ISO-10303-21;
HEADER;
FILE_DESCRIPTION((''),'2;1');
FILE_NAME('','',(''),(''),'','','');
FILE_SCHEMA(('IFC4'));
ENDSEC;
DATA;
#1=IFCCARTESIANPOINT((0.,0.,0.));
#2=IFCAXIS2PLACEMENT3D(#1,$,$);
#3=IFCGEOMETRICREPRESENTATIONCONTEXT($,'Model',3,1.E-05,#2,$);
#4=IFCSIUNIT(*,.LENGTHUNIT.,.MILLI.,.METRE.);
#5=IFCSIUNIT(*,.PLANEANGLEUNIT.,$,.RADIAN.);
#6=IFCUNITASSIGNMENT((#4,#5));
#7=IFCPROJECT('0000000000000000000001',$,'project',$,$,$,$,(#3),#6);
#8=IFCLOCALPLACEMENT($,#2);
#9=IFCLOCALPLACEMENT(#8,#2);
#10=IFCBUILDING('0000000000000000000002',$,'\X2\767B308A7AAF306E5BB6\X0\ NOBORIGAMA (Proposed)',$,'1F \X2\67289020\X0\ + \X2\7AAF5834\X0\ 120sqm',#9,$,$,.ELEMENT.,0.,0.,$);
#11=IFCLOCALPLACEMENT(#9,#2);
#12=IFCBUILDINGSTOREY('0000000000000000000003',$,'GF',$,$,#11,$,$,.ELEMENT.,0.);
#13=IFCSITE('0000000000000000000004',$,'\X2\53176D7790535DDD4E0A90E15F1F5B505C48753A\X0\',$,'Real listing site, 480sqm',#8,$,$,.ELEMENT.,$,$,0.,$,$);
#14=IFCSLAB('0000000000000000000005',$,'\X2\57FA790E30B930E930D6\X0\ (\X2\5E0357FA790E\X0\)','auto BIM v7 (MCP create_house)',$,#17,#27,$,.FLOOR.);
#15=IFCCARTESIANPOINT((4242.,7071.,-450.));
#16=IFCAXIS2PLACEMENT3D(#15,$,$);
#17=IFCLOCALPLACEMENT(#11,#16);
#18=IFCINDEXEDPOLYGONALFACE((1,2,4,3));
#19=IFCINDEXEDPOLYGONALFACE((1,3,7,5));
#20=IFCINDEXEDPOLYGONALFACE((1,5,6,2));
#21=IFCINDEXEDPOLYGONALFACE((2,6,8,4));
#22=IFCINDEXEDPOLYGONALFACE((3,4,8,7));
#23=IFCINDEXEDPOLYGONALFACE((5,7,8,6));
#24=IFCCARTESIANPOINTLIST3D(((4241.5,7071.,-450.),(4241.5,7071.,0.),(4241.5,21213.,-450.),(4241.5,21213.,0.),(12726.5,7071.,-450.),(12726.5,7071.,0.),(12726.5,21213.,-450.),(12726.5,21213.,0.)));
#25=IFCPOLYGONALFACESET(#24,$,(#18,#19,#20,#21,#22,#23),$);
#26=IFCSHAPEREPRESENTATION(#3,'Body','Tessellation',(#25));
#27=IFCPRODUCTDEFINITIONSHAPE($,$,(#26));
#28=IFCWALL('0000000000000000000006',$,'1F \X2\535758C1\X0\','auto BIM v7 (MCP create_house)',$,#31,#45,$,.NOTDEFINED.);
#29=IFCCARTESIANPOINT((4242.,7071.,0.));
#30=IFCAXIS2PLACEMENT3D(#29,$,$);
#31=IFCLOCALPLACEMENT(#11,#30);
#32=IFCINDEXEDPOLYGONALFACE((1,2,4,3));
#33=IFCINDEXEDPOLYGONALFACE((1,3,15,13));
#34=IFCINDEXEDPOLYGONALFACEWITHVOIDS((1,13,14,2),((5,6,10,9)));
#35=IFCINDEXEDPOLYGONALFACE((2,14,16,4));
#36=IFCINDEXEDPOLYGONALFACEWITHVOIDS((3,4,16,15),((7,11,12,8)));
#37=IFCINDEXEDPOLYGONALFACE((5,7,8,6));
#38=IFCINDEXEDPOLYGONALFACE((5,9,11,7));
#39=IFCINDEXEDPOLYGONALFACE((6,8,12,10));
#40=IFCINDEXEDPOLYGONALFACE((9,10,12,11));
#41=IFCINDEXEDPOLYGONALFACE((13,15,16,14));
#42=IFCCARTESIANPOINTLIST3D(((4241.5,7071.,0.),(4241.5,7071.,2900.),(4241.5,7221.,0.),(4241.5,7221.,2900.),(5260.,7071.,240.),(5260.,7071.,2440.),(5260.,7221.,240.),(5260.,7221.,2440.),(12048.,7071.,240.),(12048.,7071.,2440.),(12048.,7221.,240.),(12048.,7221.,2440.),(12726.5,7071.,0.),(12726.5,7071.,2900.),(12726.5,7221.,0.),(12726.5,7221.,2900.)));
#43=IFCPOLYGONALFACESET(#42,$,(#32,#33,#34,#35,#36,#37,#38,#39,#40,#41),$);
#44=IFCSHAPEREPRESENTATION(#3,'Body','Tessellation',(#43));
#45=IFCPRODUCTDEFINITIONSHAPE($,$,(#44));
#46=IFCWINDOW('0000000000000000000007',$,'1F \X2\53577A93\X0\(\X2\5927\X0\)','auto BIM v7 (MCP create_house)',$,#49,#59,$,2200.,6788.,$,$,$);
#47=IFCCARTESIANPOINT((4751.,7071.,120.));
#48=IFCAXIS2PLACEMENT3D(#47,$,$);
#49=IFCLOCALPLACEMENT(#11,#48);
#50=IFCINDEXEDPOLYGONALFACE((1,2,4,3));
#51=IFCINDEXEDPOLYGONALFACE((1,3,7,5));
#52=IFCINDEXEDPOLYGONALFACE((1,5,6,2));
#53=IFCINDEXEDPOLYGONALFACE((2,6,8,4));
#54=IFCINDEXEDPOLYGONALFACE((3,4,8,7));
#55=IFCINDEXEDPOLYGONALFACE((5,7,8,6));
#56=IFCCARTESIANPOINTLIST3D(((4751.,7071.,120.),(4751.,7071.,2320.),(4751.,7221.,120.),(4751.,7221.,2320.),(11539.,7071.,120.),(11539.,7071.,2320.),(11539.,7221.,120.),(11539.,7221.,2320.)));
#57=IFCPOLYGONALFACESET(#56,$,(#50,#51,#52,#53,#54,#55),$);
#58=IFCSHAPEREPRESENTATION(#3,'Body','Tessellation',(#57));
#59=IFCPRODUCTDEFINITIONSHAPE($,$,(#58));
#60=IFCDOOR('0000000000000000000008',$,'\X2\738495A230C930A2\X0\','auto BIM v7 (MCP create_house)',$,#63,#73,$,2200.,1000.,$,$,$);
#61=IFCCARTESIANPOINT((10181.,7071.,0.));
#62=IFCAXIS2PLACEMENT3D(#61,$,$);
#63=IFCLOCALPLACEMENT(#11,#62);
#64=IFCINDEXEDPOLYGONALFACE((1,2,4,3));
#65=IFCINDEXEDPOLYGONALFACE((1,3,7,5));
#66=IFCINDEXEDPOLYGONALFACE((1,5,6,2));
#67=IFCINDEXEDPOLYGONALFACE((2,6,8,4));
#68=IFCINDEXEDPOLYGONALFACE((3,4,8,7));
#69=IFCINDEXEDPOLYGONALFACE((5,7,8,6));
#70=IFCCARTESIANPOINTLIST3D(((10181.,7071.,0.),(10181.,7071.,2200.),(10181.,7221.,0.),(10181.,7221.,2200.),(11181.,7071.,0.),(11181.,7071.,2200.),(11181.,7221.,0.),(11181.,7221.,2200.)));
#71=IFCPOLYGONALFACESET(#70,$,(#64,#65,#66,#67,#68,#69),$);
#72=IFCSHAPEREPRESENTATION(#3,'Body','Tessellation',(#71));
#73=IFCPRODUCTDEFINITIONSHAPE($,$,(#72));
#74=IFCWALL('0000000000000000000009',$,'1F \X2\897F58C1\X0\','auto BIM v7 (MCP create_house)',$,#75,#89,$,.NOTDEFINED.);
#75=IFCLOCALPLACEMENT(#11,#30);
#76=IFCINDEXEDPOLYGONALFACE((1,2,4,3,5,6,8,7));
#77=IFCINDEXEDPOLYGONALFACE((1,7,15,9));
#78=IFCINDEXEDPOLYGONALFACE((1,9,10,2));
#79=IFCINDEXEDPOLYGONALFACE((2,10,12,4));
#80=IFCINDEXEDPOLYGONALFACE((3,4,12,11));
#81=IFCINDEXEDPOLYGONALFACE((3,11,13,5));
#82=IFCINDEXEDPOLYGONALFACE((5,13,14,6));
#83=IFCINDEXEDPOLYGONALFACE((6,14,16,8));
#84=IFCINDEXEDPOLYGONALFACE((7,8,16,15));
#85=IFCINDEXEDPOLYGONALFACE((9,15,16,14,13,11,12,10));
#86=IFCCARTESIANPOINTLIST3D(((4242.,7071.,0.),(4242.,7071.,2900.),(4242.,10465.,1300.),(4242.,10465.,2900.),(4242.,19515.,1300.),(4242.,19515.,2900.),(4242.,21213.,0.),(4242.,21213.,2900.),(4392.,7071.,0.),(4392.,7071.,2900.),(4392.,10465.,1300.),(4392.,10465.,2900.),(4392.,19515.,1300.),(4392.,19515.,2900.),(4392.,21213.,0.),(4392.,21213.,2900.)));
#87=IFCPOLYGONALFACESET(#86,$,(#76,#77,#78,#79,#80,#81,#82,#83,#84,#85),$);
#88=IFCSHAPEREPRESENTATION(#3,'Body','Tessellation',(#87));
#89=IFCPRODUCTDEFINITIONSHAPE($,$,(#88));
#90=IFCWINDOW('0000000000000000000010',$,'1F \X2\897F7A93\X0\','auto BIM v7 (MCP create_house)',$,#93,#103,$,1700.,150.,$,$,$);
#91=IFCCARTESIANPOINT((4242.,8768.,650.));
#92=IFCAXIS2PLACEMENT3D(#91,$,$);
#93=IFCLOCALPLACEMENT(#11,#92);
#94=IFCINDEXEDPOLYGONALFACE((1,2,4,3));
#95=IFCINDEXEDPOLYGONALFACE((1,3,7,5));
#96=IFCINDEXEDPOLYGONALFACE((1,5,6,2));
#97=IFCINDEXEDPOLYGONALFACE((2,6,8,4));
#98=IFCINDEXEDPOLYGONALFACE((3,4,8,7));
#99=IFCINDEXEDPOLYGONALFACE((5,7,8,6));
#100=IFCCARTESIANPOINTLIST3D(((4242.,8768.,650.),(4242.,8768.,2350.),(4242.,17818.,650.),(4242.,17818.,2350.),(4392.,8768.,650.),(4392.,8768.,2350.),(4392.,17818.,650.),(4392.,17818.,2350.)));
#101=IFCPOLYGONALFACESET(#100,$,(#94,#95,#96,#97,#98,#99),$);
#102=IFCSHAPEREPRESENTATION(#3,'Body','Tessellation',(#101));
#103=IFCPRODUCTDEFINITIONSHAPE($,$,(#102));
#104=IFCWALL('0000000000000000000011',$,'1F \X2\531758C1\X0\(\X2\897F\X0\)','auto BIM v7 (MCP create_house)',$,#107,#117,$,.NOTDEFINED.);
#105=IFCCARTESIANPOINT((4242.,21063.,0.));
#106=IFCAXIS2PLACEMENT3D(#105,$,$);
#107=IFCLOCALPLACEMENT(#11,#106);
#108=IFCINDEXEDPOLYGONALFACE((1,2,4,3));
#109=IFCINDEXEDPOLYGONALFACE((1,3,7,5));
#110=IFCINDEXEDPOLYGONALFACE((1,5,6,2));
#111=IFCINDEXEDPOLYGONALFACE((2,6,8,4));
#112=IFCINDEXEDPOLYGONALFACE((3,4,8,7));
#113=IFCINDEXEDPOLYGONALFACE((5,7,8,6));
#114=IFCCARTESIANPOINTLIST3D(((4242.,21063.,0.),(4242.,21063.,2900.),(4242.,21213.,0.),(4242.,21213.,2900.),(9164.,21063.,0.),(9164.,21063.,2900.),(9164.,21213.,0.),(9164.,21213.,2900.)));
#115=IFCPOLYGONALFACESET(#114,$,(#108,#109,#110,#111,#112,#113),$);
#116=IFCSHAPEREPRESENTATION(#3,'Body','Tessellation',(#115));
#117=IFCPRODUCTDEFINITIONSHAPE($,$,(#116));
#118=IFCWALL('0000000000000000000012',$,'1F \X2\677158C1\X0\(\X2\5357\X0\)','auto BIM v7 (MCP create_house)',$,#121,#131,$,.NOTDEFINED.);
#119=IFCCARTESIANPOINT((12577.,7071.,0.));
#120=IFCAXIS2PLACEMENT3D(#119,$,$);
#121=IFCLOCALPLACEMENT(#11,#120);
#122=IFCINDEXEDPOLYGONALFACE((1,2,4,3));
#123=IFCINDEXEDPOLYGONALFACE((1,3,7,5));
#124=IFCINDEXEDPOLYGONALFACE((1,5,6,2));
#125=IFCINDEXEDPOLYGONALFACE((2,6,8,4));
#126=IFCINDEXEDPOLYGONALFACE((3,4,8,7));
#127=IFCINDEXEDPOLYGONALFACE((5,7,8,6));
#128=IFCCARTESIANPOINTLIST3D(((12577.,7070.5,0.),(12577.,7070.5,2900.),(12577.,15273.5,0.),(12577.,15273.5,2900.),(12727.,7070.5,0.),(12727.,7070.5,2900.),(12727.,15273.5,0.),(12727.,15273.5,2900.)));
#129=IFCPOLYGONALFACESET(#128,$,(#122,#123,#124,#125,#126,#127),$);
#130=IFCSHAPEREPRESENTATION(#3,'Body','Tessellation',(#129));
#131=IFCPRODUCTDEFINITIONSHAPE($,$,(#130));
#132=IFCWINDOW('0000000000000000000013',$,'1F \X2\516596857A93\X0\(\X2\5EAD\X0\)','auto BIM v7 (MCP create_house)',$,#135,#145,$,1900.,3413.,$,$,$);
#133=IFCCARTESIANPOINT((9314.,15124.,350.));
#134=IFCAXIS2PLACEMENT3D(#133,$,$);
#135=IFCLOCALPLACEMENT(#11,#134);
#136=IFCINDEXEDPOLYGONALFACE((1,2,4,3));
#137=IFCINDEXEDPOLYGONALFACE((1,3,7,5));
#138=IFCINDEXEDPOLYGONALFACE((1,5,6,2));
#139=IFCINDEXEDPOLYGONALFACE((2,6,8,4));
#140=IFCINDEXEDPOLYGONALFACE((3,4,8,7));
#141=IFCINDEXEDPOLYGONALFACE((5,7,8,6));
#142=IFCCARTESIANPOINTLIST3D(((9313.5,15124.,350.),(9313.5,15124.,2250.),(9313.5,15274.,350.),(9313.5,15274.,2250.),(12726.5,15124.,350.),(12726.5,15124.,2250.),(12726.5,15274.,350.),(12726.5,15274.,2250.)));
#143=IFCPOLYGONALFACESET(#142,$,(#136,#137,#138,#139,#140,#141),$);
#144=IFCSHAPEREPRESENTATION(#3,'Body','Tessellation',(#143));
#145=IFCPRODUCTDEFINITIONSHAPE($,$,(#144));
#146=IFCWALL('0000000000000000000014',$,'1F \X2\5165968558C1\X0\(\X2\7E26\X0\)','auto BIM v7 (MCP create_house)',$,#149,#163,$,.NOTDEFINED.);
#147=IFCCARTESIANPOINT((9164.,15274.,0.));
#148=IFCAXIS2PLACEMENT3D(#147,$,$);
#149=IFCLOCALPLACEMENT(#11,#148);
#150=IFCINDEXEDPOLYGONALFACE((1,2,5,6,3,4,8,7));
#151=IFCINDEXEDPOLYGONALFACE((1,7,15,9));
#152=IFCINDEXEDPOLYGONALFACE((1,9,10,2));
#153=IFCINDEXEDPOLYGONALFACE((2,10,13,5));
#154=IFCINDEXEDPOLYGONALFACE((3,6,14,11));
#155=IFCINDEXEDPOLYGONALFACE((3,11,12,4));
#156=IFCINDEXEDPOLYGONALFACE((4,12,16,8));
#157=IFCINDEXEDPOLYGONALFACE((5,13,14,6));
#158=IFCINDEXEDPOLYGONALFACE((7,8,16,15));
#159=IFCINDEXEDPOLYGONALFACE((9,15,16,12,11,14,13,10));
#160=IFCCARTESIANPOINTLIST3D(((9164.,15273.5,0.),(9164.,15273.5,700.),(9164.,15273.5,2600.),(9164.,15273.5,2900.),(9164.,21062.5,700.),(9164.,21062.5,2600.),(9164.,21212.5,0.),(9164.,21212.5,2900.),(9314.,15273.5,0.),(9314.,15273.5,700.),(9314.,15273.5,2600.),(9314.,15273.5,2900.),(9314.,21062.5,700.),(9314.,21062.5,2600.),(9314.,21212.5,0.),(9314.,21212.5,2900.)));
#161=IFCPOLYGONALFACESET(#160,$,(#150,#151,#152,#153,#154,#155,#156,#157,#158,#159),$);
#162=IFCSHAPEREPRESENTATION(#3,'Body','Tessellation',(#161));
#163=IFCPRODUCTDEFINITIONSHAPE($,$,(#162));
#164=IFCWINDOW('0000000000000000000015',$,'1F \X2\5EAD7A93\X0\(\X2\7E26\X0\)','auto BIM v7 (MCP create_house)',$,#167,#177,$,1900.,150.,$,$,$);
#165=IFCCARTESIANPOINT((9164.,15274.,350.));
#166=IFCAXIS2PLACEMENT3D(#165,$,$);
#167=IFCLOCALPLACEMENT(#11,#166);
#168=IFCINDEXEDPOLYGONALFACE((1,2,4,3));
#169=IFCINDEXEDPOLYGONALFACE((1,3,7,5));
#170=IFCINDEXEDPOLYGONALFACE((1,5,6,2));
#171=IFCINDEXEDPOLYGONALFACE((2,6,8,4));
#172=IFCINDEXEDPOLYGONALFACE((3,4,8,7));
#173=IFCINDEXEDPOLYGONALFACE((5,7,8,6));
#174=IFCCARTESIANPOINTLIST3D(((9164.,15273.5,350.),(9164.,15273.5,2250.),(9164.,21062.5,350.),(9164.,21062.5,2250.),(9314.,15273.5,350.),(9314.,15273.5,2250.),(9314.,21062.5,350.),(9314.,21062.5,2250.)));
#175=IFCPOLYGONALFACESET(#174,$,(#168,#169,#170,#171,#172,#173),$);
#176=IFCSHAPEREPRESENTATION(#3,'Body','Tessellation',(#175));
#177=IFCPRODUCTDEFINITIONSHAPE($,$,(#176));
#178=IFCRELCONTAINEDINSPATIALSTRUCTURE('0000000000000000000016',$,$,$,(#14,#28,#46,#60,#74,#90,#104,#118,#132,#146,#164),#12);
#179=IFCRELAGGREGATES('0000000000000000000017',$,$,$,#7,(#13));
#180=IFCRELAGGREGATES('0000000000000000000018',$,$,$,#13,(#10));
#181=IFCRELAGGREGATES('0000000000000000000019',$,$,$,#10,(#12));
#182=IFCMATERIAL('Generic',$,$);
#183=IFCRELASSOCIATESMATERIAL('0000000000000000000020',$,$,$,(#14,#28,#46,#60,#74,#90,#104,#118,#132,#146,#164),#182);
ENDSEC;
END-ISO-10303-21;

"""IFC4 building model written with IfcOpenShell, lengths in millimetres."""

from ifc_helpers import new_model, si_unit, frame, frame_2d, origin, place, context, project, spatial, rectangle, extrude, material, element, fill, save


model = new_model("IFC4")

# Units and contexts
model_context = context("Model", 3, precision=1e-05, world=origin())
ifc_project = project(units=[si_unit("LENGTHUNIT", "METRE", prefix="MILLI"), si_unit("PLANEANGLEUNIT", "RADIAN")], contexts=[model_context])

# Site, building, storey
site_placement = place(None, origin())
site = spatial("IfcSite", under=ifc_project, at=site_placement, Name="北海道川上郡弟子屈町", ObjectType="Real listing site, 480sqm", CompositionType="ELEMENT", RefElevation=0.0)
building_placement = place(site_placement, origin())
building = spatial("IfcBuilding", under=site, at=building_placement, Name="登り窯の家 NOBORIGAMA (Proposed)", ObjectType="1F 木造 + 窯場 120sqm", CompositionType="ELEMENT", ElevationOfRefHeight=0.0, ElevationOfTerrain=0.0)
storey_placement = place(building_placement, origin())
storey = spatial("IfcBuildingStorey", under=building, at=storey_placement, Name="GF", CompositionType="ELEMENT", Elevation=0.0)

# Slab
ifc_material = material(Name="Generic")
slab_1_placement = place(storey_placement, frame((4242.0, 7071.0, -450.0)))
element("IfcSlab", 1, at=slab_1_placement, inside=storey, material=ifc_material, Name="基礎スラブ (布基礎)", Description="auto BIM v7 (MCP create_house)", PredefinedType="FLOOR", context=model_context, shape_type="SweptSolid", body=[
    extrude(rectangle(XDim=8485.0, YDim=14142.0, at=frame_2d((4242.0, 7071.0))), frame((4242.0, 7071.0, -450.0)), (0.0, 0.0, 1.0), 450.0),
])

# Wall, openings, window, door
wall_1_placement = place(storey_placement, frame((4242.0, 7071.0, 0.0)))
wall_1 = element("IfcWall", 2, at=wall_1_placement, inside=storey, material=ifc_material, Name="1F 南壁", Description="auto BIM v7 (MCP create_house)", PredefinedType="NOTDEFINED", context=model_context, shape_type="SweptSolid", body=[
    extrude(rectangle(XDim=8485.0, YDim=150.0, at=frame_2d((4242.0, 75.0))), frame((4242.0, 7071.0, 0.0)), (0.0, 0.0, 1.0), 2900.0),
])
opening_1_placement = place(storey_placement, frame((4751.0, 7071.0, 120.0)))
opening_1 = element("IfcOpeningElement", 3, at=opening_1_placement, cuts=wall_1, PredefinedType="NOTDEFINED", context=model_context, shape_type="SweptSolid", body=[
    extrude(rectangle(XDim=6788.0, YDim=150.0, at=frame_2d((3394.0, 75.0))), frame((4751.0, 7071.0, 120.0)), (0.0, 0.0, 1.0), 2200.0),
])
opening_2_placement = place(storey_placement, frame((10181.0, 7071.0, 0.0)))
opening_2 = element("IfcOpeningElement", 4, at=opening_2_placement, cuts=wall_1, PredefinedType="NOTDEFINED", context=model_context, shape_type="SweptSolid", body=[
    extrude(rectangle(XDim=1000.0, YDim=150.0, at=frame_2d((500.0, 75.0))), frame((10181.0, 7071.0, 0.0)), (0.0, 0.0, 1.0), 2200.0),
])
window_1_placement = place(storey_placement, frame((4751.0, 7071.0, 120.0)))
window_1 = element("IfcWindow", 5, at=window_1_placement, inside=storey, material=ifc_material, Name="1F 南窓(大)", Description="auto BIM v7 (MCP create_house)", OverallHeight=2200.0, OverallWidth=6788.0, context=model_context, shape_type="SweptSolid", body=[
    extrude(rectangle(XDim=6788.0, YDim=150.0, at=frame_2d((3394.0, 75.0))), frame((4751.0, 7071.0, 120.0)), (0.0, 0.0, 1.0), 2200.0),
])
fill(opening_1, window_1)
door_placement = place(storey_placement, frame((10181.0, 7071.0, 0.0)))
door = element("IfcDoor", 6, at=door_placement, inside=storey, material=ifc_material, Name="玄関ドア", Description="auto BIM v7 (MCP create_house)", OverallHeight=2200.0, OverallWidth=1000.0, context=model_context, shape_type="SweptSolid", body=[
    extrude(rectangle(XDim=1000.0, YDim=150.0, at=frame_2d((500.0, 75.0))), frame((10181.0, 7071.0, 0.0)), (0.0, 0.0, 1.0), 2200.0),
])
fill(opening_2, door)

# Wall, opening, window
wall_2_placement = place(storey_placement, frame((4242.0, 7071.0, 0.0)))
wall_2 = element("IfcWall", 7, at=wall_2_placement, inside=storey, material=ifc_material, Name="1F 西壁", Description="auto BIM v7 (MCP create_house)", PredefinedType="NOTDEFINED", context=model_context, shape_type="SweptSolid", body=[
    extrude(rectangle(XDim=150.0, YDim=14142.0, at=frame_2d((75.0, 7071.0))), frame((4242.0, 7071.0, 0.0)), (0.0, 0.0, 1.0), 2900.0),
])
opening_3_placement = place(storey_placement, frame((4242.0, 8768.0, 650.0)))
opening_3 = element("IfcOpeningElement", 8, at=opening_3_placement, cuts=wall_2, PredefinedType="NOTDEFINED", context=model_context, shape_type="SweptSolid", body=[
    extrude(rectangle(XDim=150.0, YDim=9050.0, at=frame_2d((75.0, 4525.0))), frame((4242.0, 8768.0, 650.0)), (0.0, 0.0, 1.0), 1700.0),
])
window_2_placement = place(storey_placement, frame((4242.0, 8768.0, 650.0)))
window_2 = element("IfcWindow", 9, at=window_2_placement, inside=storey, material=ifc_material, Name="1F 西窓", Description="auto BIM v7 (MCP create_house)", OverallHeight=1700.0, OverallWidth=150.0, context=model_context, shape_type="SweptSolid", body=[
    extrude(rectangle(XDim=150.0, YDim=9050.0, at=frame_2d((75.0, 4525.0))), frame((4242.0, 8768.0, 650.0)), (0.0, 0.0, 1.0), 1700.0),
])
fill(opening_3, window_2)

# Wall
wall_3_placement = place(storey_placement, frame((4242.0, 21063.0, 0.0)))
element("IfcWall", 10, at=wall_3_placement, inside=storey, material=ifc_material, Name="1F 北壁(西)", Description="auto BIM v7 (MCP create_house)", PredefinedType="NOTDEFINED", context=model_context, shape_type="SweptSolid", body=[
    extrude(rectangle(XDim=4922.0, YDim=150.0, at=frame_2d((2461.0, 75.0))), frame((4242.0, 21063.0, 0.0)), (0.0, 0.0, 1.0), 2900.0),
])

# Wall, opening, window
wall_4_placement = place(storey_placement, frame((12577.0, 7071.0, 0.0)))
wall_4 = element("IfcWall", 11, at=wall_4_placement, inside=storey, material=ifc_material, Name="1F 東壁(南)", Description="auto BIM v7 (MCP create_house)", PredefinedType="NOTDEFINED", context=model_context, shape_type="SweptSolid", body=[
    extrude(rectangle(XDim=150.0, YDim=8203.0, at=frame_2d((75.0, 4101.0))), frame((12577.0, 7071.0, 0.0)), (0.0, 0.0, 1.0), 2900.0),
])
opening_4_placement = place(storey_placement, frame((9314.0, 15124.0, 350.0)))
opening_4 = element("IfcOpeningElement", 12, at=opening_4_placement, cuts=wall_4, PredefinedType="NOTDEFINED", context=model_context, shape_type="SweptSolid", body=[
    extrude(rectangle(XDim=3413.0, YDim=150.0, at=frame_2d((1706.0, 75.0))), frame((9314.0, 15124.0, 350.0)), (0.0, 0.0, 1.0), 1900.0),
])
window_3_placement = place(storey_placement, frame((9314.0, 15124.0, 350.0)))
window_3 = element("IfcWindow", 13, at=window_3_placement, inside=storey, material=ifc_material, Name="1F 入隅窓(庭)", Description="auto BIM v7 (MCP create_house)", OverallHeight=1900.0, OverallWidth=3413.0, context=model_context, shape_type="SweptSolid", body=[
    extrude(rectangle(XDim=3413.0, YDim=150.0, at=frame_2d((1706.0, 75.0))), frame((9314.0, 15124.0, 350.0)), (0.0, 0.0, 1.0), 1900.0),
])
fill(opening_4, window_3)

# Wall, opening, window
wall_5_placement = place(storey_placement, frame((9164.0, 15274.0, 0.0)))
wall_5 = element("IfcWall", 14, at=wall_5_placement, inside=storey, material=ifc_material, Name="1F 入隅壁(縦)", Description="auto BIM v7 (MCP create_house)", PredefinedType="NOTDEFINED", context=model_context, shape_type="SweptSolid", body=[
    extrude(rectangle(XDim=150.0, YDim=5939.0, at=frame_2d((75.0, 2969.0))), frame((9164.0, 15274.0, 0.0)), (0.0, 0.0, 1.0), 2900.0),
])
opening_5_placement = place(storey_placement, frame((9164.0, 15274.0, 350.0)))
opening_5 = element("IfcOpeningElement", 15, at=opening_5_placement, cuts=wall_5, PredefinedType="NOTDEFINED", context=model_context, shape_type="SweptSolid", body=[
    extrude(rectangle(XDim=150.0, YDim=5789.0, at=frame_2d((75.0, 2894.0))), frame((9164.0, 15274.0, 350.0)), (0.0, 0.0, 1.0), 1900.0),
])
window_4_placement = place(storey_placement, frame((9164.0, 15274.0, 350.0)))
window_4 = element("IfcWindow", 16, at=window_4_placement, inside=storey, material=ifc_material, Name="1F 庭窓(縦)", Description="auto BIM v7 (MCP create_house)", OverallHeight=1900.0, OverallWidth=150.0, context=model_context, shape_type="SweptSolid", body=[
    extrude(rectangle(XDim=150.0, YDim=5789.0, at=frame_2d((75.0, 2894.0))), frame((9164.0, 15274.0, 350.0)), (0.0, 0.0, 1.0), 1900.0),
])
fill(opening_5, window_4)

save(model, "model.ifc")
